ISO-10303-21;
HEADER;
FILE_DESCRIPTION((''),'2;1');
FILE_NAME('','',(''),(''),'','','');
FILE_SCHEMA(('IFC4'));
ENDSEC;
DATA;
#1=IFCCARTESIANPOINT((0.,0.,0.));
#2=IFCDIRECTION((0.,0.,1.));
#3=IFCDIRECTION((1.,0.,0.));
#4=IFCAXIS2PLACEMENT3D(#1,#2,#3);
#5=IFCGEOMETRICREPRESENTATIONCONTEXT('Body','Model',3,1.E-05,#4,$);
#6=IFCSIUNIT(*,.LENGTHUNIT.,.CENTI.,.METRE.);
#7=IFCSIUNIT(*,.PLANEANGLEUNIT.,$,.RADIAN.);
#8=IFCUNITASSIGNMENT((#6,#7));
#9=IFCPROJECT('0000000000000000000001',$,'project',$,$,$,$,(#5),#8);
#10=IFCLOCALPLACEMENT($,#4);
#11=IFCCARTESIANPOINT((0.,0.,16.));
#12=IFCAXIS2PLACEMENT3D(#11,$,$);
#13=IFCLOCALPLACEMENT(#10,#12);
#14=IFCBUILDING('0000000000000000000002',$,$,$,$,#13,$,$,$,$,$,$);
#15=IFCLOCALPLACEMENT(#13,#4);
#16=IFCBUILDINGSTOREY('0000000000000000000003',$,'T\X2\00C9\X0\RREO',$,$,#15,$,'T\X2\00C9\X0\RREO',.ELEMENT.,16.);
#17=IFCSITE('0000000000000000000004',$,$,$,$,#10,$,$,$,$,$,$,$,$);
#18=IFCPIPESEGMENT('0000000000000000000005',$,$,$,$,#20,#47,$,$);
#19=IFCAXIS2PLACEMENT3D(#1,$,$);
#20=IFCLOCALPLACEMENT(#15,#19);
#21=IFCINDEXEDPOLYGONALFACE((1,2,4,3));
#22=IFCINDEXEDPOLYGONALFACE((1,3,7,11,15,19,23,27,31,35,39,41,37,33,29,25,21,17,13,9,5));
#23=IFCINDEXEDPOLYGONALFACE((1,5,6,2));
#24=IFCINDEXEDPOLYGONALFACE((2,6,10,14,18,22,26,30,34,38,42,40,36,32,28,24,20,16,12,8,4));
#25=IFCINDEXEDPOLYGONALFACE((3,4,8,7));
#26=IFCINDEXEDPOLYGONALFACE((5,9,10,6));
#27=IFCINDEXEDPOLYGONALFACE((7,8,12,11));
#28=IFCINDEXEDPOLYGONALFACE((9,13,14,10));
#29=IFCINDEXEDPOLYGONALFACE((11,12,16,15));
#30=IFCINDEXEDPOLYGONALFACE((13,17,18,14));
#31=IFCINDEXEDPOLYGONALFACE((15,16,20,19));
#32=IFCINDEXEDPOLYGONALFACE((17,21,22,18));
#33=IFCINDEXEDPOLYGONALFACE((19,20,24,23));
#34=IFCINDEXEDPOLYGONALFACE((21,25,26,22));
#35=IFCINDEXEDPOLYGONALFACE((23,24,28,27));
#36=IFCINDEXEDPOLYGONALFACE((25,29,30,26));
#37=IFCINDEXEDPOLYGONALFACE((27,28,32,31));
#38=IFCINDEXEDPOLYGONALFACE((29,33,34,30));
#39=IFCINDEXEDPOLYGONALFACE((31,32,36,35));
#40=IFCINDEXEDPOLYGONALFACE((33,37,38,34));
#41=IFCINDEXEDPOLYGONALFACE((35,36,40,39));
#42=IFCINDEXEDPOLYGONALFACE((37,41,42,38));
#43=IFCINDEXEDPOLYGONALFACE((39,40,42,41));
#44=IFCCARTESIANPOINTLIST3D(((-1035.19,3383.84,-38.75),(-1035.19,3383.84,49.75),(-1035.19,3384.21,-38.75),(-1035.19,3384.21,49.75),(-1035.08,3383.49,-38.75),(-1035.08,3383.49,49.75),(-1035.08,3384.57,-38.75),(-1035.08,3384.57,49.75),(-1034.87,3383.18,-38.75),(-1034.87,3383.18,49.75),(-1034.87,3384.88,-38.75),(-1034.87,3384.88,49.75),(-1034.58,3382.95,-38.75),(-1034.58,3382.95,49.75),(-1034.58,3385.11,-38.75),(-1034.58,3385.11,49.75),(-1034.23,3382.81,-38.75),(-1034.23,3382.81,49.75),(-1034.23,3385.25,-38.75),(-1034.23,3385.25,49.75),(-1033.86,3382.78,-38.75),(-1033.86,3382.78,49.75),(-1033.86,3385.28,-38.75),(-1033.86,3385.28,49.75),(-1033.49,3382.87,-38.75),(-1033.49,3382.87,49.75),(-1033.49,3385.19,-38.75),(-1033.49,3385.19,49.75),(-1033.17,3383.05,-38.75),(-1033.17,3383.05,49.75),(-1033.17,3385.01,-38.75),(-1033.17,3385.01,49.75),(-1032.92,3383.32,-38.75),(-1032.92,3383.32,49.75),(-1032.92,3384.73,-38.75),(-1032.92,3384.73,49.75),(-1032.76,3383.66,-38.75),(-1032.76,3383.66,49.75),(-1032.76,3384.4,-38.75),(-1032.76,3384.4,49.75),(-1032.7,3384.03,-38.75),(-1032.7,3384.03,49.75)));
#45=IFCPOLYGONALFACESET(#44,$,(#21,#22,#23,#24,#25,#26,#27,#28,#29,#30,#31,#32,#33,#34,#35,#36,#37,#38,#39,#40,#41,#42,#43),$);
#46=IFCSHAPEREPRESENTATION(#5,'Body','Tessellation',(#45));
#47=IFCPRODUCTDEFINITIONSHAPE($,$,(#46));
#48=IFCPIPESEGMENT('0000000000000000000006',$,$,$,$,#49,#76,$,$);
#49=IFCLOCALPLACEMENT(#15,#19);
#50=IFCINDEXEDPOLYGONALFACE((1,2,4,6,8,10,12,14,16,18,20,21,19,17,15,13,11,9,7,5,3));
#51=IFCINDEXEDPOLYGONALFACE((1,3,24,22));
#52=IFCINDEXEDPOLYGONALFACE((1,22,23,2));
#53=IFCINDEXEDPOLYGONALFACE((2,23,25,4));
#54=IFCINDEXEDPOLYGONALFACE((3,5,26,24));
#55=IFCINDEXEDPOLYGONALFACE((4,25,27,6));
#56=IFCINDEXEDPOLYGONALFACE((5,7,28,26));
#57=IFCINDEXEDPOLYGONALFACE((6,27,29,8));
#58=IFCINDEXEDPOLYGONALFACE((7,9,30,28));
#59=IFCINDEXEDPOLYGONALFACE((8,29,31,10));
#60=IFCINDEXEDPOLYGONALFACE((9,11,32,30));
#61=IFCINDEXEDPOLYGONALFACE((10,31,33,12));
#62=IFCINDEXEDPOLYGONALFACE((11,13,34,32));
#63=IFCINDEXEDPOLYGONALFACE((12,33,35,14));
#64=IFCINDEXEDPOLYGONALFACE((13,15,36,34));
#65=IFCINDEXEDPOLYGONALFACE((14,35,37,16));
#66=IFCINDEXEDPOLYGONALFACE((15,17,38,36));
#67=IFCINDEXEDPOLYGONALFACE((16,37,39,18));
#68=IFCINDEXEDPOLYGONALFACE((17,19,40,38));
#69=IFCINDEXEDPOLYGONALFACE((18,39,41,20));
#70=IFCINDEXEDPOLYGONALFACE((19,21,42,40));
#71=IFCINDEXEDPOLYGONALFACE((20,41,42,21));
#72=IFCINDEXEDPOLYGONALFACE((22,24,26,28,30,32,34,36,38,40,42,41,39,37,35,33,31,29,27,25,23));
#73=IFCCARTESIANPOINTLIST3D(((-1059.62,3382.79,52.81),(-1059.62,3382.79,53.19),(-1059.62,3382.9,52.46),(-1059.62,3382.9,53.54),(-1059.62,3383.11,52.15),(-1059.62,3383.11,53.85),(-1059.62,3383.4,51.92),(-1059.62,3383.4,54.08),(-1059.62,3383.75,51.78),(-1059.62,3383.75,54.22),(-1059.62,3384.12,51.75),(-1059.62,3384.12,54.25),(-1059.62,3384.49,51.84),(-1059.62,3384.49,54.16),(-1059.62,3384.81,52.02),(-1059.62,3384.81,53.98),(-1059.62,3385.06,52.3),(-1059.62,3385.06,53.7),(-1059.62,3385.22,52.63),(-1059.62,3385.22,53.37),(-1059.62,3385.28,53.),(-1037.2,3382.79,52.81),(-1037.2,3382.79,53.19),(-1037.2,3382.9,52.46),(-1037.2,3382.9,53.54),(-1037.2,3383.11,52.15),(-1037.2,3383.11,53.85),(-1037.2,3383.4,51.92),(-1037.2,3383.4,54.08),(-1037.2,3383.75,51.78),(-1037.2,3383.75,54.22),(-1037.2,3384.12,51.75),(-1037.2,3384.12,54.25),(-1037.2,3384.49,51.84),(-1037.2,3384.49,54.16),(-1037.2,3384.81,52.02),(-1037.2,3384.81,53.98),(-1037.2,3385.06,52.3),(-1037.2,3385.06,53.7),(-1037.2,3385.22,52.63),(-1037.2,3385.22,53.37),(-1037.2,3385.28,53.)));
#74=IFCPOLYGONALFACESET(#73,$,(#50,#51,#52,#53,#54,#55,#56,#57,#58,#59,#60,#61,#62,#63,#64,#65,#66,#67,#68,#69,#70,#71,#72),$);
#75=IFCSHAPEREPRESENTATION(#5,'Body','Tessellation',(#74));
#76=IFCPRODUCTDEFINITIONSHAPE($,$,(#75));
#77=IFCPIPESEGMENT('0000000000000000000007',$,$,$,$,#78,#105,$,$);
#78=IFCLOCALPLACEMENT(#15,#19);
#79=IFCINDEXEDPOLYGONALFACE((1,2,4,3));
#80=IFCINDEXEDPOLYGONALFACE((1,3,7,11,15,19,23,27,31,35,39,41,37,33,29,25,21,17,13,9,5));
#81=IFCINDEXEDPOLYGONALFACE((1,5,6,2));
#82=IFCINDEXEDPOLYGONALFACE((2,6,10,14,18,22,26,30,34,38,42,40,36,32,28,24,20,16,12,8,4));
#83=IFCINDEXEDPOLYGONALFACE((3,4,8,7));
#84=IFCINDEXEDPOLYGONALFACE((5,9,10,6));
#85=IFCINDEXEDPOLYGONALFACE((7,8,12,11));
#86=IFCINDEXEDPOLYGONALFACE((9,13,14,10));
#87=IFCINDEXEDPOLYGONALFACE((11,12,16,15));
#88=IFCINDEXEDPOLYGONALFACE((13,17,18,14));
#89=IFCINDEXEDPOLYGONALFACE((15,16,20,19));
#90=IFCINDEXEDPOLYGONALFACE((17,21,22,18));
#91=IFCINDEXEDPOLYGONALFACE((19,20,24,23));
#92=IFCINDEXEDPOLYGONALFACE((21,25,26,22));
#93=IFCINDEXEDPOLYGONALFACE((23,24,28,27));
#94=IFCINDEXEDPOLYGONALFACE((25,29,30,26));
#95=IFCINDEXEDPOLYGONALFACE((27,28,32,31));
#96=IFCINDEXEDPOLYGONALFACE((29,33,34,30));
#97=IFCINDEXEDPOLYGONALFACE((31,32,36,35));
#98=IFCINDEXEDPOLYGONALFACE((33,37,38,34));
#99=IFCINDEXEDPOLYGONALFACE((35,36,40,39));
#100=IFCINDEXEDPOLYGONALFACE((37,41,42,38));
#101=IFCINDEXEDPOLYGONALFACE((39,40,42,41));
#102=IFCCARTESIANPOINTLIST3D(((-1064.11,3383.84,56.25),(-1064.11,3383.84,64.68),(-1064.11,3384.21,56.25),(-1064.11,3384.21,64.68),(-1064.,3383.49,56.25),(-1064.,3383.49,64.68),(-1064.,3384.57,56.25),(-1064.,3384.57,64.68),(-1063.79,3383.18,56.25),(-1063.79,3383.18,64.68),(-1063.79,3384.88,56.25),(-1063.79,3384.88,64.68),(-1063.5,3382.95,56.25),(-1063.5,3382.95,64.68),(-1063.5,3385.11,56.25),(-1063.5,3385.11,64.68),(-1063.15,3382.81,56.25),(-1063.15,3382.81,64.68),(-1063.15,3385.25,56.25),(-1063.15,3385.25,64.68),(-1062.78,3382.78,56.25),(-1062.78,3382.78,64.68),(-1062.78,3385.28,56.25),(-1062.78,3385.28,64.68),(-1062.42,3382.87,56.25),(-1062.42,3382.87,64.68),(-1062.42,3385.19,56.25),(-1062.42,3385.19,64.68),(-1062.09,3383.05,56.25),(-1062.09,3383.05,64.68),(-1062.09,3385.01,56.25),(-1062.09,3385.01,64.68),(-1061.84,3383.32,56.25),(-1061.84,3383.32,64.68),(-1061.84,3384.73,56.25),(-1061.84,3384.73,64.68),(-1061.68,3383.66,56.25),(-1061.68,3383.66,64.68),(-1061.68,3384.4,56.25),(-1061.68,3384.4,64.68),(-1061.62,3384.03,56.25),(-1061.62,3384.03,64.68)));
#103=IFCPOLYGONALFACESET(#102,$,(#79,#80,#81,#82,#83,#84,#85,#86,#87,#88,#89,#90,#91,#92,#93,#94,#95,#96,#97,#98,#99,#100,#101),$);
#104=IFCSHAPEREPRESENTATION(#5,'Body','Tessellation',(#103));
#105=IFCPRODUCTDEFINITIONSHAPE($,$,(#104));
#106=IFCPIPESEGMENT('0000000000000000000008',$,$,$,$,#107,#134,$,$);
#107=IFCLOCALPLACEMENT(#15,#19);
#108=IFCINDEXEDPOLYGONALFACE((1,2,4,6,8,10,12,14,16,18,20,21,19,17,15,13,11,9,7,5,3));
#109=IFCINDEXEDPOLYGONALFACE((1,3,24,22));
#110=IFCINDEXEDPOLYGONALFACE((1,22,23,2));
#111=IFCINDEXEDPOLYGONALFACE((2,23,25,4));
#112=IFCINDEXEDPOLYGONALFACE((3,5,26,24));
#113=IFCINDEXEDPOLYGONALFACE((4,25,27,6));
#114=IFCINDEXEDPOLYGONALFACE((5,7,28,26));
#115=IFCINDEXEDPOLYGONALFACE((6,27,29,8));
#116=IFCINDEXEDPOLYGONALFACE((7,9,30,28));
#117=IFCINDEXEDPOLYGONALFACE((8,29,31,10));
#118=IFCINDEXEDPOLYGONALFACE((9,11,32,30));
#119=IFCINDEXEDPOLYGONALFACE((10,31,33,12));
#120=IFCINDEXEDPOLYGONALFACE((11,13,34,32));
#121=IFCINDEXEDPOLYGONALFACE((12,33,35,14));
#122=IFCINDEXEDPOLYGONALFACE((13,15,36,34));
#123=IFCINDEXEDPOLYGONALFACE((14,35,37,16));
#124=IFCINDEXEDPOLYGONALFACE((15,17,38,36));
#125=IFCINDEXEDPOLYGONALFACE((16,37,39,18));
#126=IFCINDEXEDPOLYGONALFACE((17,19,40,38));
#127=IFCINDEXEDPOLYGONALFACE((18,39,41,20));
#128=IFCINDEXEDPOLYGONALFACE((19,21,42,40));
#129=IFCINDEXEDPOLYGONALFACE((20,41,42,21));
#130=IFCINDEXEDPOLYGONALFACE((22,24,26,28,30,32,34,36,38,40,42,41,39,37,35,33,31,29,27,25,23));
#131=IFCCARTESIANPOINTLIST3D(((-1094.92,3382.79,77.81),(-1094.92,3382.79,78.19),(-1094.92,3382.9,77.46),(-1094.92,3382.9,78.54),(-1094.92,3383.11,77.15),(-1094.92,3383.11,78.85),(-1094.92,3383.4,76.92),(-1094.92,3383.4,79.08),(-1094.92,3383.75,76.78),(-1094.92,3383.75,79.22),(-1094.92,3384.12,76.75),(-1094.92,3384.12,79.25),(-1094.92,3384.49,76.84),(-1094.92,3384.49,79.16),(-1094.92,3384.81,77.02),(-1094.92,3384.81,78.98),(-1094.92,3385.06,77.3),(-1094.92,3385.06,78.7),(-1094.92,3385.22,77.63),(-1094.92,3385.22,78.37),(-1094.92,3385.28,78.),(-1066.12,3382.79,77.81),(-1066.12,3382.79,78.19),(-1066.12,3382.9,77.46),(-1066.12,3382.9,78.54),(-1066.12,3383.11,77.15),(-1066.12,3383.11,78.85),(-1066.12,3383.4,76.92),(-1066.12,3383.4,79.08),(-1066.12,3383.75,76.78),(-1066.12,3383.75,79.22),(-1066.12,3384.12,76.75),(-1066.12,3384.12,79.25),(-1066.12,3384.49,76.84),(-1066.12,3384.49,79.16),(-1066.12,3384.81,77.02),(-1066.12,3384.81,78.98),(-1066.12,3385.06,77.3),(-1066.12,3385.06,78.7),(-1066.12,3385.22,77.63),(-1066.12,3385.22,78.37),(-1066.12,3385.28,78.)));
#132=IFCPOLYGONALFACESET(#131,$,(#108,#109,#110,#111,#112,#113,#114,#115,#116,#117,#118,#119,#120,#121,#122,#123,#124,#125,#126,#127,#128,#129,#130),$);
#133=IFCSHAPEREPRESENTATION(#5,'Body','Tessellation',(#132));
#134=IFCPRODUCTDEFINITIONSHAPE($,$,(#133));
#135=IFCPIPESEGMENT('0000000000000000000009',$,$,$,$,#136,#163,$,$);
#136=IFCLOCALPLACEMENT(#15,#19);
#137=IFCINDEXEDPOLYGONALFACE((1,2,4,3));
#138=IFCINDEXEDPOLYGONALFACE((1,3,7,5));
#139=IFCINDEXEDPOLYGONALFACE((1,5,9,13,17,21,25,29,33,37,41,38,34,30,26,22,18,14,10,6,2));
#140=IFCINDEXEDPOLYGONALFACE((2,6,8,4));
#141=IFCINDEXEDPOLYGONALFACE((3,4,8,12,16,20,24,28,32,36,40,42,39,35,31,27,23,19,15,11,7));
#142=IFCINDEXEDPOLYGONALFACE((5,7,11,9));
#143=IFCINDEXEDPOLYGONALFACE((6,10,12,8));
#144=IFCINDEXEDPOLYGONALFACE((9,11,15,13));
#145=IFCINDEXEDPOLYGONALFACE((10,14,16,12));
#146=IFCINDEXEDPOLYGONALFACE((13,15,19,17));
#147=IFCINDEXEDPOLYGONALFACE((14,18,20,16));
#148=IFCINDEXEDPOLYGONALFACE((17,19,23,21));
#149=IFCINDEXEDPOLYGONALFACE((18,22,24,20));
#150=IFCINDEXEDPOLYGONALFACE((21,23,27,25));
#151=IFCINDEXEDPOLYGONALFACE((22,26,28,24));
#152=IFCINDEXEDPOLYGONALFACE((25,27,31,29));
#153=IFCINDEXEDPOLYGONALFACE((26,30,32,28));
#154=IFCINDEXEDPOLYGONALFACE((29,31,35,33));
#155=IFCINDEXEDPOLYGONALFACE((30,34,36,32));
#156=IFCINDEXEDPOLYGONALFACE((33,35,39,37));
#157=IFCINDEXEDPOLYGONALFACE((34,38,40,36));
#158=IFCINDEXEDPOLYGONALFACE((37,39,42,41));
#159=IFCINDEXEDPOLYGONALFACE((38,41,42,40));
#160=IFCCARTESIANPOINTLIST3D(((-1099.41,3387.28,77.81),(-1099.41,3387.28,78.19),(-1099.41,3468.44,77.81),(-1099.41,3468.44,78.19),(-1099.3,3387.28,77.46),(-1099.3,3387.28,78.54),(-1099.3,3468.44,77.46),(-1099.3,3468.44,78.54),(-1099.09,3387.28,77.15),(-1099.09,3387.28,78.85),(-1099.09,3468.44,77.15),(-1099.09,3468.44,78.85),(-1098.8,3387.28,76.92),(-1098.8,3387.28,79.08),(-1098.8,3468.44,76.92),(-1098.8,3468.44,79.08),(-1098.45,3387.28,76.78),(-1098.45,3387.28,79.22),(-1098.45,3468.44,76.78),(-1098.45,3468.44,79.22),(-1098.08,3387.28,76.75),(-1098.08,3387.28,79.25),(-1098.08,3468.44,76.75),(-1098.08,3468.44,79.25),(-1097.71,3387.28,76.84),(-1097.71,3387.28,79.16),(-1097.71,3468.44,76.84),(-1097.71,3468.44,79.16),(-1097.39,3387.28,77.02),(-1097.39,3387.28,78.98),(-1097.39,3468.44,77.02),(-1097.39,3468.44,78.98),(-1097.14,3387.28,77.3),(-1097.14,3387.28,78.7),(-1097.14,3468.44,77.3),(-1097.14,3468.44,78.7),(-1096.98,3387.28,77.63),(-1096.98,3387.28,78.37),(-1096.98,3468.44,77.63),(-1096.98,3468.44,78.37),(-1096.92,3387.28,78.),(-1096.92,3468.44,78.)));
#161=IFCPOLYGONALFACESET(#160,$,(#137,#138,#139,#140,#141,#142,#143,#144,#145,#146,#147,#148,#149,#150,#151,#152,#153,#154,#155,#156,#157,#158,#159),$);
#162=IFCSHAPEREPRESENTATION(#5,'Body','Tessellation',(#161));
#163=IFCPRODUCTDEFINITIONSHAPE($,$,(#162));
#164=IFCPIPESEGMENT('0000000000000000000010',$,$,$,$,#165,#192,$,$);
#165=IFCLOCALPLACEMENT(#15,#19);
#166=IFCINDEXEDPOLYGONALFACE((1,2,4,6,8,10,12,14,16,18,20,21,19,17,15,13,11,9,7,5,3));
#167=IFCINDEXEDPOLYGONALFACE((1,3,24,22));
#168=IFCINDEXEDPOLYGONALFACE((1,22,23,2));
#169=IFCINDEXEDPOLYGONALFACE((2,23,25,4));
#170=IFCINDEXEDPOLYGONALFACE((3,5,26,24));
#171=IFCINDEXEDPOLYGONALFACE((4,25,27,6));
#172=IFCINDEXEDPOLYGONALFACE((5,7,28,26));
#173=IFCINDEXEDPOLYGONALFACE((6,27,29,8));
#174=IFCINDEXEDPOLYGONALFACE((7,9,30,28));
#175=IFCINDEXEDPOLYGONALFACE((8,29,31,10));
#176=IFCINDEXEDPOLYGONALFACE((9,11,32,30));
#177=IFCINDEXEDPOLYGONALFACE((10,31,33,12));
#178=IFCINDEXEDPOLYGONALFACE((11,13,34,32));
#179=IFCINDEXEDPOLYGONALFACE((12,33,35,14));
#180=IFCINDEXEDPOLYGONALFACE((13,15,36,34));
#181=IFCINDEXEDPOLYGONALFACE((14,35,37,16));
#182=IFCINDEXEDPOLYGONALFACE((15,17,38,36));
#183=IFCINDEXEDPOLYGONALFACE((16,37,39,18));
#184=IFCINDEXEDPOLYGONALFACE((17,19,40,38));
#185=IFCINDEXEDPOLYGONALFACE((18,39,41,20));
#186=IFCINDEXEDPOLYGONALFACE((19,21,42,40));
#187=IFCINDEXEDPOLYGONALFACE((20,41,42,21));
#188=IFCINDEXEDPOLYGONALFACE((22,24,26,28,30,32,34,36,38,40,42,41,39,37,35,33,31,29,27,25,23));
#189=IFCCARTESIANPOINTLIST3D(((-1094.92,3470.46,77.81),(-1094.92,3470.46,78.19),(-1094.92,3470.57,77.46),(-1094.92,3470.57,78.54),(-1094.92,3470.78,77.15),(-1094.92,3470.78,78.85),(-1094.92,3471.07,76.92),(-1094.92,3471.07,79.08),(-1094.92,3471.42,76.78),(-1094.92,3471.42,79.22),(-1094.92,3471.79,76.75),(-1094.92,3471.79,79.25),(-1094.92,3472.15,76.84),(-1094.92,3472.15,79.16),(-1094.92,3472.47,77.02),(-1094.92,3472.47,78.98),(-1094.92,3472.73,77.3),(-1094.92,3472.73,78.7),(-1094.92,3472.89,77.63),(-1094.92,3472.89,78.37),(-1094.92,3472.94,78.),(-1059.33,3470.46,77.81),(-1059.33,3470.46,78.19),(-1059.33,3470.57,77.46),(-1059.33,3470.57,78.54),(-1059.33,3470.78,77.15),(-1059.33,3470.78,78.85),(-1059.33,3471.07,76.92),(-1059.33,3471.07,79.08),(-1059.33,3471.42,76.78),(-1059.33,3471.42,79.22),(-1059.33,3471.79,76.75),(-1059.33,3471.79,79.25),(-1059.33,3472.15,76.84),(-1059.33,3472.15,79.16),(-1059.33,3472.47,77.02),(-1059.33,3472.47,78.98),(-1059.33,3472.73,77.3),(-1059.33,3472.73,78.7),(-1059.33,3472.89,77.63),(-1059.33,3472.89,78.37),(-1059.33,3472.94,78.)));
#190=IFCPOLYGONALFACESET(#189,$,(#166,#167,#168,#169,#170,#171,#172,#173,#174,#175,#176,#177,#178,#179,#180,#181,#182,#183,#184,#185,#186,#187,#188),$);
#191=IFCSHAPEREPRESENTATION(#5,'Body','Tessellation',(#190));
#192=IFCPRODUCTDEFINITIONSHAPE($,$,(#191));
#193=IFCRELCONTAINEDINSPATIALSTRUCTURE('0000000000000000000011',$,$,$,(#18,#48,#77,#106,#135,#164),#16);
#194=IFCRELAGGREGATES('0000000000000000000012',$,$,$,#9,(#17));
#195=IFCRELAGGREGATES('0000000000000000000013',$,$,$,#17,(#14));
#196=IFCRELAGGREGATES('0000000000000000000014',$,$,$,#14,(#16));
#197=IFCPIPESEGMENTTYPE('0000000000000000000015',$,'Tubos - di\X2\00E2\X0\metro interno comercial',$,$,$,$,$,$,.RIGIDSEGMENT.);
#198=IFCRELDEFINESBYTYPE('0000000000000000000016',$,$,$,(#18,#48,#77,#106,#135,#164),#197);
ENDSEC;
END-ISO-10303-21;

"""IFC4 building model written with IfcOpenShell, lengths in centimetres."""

from ifc_helpers import new_model, si_unit, frame, origin_with_axes, origin_2d_with_axis, place, context, project, spatial, circle, extrude, type_object, element, save


model = new_model("IFC4")

# Units and contexts
model_context = context("Model", 3, precision=1e-05, world=origin_with_axes(), identifier="Body")
ifc_project = project(units=[si_unit("LENGTHUNIT", "METRE", prefix="CENTI"), si_unit("PLANEANGLEUNIT", "RADIAN")], contexts=[model_context])

# Site, building, storey
site_placement = place(None, origin_with_axes())
site = spatial("IfcSite", under=ifc_project, at=site_placement)
building_placement = place(site_placement, frame((0.0, 0.0, 16.0)))
building = spatial("IfcBuilding", under=site, at=building_placement)
storey_placement = place(building_placement, origin_with_axes())
storey = spatial("IfcBuildingStorey", under=building, at=storey_placement, Name="TÉRREO", LongName="TÉRREO", CompositionType="ELEMENT", Elevation=16.0)

# Pipe segments
pipe_segment_type = type_object("IfcPipeSegmentType", Name="Tubos - diâmetro interno comercial", PredefinedType="RIGIDSEGMENT")
pipe_segment_1_placement = place(storey_placement, frame((-1033.95, 3384.03, 49.75), z_axis=(0.0, 0.0, 1.0), x_axis=(1.0, 0.0, 0.0)))
element("IfcPipeSegment", 1, at=pipe_segment_1_placement, inside=storey, type_object=pipe_segment_type, context=model_context, shape_type="SolidModel", body=[
    extrude(circle(Radius=1.25, at=origin_2d_with_axis()), frame((0.0, 0.0, -88.5), z_axis=(0.0, 0.0, 1.0), x_axis=(1.0, 0.0, 0.0)), (0.0, 0.0, 1.0), 88.5),
])
pipe_segment_2_placement = place(storey_placement, frame((-1048.41, 3384.03, 54.25), z_axis=(0.0, 0.0, 1.0), x_axis=(1.0, 0.0, 0.0)))
element("IfcPipeSegment", 2, at=pipe_segment_2_placement, inside=storey, type_object=pipe_segment_type, context=model_context, shape_type="SolidModel", body=[
    extrude(circle(Radius=1.25, at=origin_2d_with_axis()), frame((11.21, 0.0, -1.25), z_axis=(-1.0, 0.0, 0.0), x_axis=(0.0, 1.0, 0.0)), (0.0, 0.0, 1.0), 22.42),
])
pipe_segment_3_placement = place(storey_placement, frame((-1062.87, 3384.03, 64.68), z_axis=(0.0, 0.0, 1.0), x_axis=(1.0, 0.0, 0.0)))
element("IfcPipeSegment", 3, at=pipe_segment_3_placement, inside=storey, type_object=pipe_segment_type, context=model_context, shape_type="SolidModel", body=[
    extrude(circle(Radius=1.25, at=origin_2d_with_axis()), frame((0.0, 0.0, -8.43), z_axis=(0.0, 0.0, 1.0), x_axis=(1.0, 0.0, 0.0)), (0.0, 0.0, 1.0), 8.43),
])
pipe_segment_4_placement = place(storey_placement, frame((-1080.52, 3384.03, 79.25), z_axis=(0.0, 0.0, 1.0), x_axis=(1.0, 0.0, 0.0)))
element("IfcPipeSegment", 4, at=pipe_segment_4_placement, inside=storey, type_object=pipe_segment_type, context=model_context, shape_type="SolidModel", body=[
    extrude(circle(Radius=1.25, at=origin_2d_with_axis()), frame((14.4, 0.0, -1.25), z_axis=(-1.0, 0.0, 0.0), x_axis=(0.0, 1.0, 0.0)), (0.0, 0.0, 1.0), 28.8),
])
pipe_segment_5_placement = place(storey_placement, frame((-1098.17, 3427.86, 79.25), z_axis=(0.0, 0.0, 1.0), x_axis=(1.0, 0.0, 0.0)))
element("IfcPipeSegment", 5, at=pipe_segment_5_placement, inside=storey, type_object=pipe_segment_type, context=model_context, shape_type="SolidModel", body=[
    extrude(circle(Radius=1.25, at=origin_2d_with_axis()), frame((0.0, -40.58, -1.25), z_axis=(0.0, 1.0, 0.0), x_axis=(1.0, 0.0, 0.0)), (0.0, 0.0, 1.0), 81.16),
])
pipe_segment_6_placement = place(storey_placement, frame((-1077.13, 3471.69, 79.25), z_axis=(0.0, 0.0, 1.0), x_axis=(1.0, 0.0, 0.0)))
element("IfcPipeSegment", 6, at=pipe_segment_6_placement, inside=storey, type_object=pipe_segment_type, context=model_context, shape_type="SolidModel", body=[
    extrude(circle(Radius=1.25, at=origin_2d_with_axis()), frame((-17.79, 0.0, -1.25), z_axis=(1.0, 0.0, 0.0), x_axis=(0.0, 1.0, 0.0)), (0.0, 0.0, 1.0), 35.59),
])

save(model, "model.ifc")
